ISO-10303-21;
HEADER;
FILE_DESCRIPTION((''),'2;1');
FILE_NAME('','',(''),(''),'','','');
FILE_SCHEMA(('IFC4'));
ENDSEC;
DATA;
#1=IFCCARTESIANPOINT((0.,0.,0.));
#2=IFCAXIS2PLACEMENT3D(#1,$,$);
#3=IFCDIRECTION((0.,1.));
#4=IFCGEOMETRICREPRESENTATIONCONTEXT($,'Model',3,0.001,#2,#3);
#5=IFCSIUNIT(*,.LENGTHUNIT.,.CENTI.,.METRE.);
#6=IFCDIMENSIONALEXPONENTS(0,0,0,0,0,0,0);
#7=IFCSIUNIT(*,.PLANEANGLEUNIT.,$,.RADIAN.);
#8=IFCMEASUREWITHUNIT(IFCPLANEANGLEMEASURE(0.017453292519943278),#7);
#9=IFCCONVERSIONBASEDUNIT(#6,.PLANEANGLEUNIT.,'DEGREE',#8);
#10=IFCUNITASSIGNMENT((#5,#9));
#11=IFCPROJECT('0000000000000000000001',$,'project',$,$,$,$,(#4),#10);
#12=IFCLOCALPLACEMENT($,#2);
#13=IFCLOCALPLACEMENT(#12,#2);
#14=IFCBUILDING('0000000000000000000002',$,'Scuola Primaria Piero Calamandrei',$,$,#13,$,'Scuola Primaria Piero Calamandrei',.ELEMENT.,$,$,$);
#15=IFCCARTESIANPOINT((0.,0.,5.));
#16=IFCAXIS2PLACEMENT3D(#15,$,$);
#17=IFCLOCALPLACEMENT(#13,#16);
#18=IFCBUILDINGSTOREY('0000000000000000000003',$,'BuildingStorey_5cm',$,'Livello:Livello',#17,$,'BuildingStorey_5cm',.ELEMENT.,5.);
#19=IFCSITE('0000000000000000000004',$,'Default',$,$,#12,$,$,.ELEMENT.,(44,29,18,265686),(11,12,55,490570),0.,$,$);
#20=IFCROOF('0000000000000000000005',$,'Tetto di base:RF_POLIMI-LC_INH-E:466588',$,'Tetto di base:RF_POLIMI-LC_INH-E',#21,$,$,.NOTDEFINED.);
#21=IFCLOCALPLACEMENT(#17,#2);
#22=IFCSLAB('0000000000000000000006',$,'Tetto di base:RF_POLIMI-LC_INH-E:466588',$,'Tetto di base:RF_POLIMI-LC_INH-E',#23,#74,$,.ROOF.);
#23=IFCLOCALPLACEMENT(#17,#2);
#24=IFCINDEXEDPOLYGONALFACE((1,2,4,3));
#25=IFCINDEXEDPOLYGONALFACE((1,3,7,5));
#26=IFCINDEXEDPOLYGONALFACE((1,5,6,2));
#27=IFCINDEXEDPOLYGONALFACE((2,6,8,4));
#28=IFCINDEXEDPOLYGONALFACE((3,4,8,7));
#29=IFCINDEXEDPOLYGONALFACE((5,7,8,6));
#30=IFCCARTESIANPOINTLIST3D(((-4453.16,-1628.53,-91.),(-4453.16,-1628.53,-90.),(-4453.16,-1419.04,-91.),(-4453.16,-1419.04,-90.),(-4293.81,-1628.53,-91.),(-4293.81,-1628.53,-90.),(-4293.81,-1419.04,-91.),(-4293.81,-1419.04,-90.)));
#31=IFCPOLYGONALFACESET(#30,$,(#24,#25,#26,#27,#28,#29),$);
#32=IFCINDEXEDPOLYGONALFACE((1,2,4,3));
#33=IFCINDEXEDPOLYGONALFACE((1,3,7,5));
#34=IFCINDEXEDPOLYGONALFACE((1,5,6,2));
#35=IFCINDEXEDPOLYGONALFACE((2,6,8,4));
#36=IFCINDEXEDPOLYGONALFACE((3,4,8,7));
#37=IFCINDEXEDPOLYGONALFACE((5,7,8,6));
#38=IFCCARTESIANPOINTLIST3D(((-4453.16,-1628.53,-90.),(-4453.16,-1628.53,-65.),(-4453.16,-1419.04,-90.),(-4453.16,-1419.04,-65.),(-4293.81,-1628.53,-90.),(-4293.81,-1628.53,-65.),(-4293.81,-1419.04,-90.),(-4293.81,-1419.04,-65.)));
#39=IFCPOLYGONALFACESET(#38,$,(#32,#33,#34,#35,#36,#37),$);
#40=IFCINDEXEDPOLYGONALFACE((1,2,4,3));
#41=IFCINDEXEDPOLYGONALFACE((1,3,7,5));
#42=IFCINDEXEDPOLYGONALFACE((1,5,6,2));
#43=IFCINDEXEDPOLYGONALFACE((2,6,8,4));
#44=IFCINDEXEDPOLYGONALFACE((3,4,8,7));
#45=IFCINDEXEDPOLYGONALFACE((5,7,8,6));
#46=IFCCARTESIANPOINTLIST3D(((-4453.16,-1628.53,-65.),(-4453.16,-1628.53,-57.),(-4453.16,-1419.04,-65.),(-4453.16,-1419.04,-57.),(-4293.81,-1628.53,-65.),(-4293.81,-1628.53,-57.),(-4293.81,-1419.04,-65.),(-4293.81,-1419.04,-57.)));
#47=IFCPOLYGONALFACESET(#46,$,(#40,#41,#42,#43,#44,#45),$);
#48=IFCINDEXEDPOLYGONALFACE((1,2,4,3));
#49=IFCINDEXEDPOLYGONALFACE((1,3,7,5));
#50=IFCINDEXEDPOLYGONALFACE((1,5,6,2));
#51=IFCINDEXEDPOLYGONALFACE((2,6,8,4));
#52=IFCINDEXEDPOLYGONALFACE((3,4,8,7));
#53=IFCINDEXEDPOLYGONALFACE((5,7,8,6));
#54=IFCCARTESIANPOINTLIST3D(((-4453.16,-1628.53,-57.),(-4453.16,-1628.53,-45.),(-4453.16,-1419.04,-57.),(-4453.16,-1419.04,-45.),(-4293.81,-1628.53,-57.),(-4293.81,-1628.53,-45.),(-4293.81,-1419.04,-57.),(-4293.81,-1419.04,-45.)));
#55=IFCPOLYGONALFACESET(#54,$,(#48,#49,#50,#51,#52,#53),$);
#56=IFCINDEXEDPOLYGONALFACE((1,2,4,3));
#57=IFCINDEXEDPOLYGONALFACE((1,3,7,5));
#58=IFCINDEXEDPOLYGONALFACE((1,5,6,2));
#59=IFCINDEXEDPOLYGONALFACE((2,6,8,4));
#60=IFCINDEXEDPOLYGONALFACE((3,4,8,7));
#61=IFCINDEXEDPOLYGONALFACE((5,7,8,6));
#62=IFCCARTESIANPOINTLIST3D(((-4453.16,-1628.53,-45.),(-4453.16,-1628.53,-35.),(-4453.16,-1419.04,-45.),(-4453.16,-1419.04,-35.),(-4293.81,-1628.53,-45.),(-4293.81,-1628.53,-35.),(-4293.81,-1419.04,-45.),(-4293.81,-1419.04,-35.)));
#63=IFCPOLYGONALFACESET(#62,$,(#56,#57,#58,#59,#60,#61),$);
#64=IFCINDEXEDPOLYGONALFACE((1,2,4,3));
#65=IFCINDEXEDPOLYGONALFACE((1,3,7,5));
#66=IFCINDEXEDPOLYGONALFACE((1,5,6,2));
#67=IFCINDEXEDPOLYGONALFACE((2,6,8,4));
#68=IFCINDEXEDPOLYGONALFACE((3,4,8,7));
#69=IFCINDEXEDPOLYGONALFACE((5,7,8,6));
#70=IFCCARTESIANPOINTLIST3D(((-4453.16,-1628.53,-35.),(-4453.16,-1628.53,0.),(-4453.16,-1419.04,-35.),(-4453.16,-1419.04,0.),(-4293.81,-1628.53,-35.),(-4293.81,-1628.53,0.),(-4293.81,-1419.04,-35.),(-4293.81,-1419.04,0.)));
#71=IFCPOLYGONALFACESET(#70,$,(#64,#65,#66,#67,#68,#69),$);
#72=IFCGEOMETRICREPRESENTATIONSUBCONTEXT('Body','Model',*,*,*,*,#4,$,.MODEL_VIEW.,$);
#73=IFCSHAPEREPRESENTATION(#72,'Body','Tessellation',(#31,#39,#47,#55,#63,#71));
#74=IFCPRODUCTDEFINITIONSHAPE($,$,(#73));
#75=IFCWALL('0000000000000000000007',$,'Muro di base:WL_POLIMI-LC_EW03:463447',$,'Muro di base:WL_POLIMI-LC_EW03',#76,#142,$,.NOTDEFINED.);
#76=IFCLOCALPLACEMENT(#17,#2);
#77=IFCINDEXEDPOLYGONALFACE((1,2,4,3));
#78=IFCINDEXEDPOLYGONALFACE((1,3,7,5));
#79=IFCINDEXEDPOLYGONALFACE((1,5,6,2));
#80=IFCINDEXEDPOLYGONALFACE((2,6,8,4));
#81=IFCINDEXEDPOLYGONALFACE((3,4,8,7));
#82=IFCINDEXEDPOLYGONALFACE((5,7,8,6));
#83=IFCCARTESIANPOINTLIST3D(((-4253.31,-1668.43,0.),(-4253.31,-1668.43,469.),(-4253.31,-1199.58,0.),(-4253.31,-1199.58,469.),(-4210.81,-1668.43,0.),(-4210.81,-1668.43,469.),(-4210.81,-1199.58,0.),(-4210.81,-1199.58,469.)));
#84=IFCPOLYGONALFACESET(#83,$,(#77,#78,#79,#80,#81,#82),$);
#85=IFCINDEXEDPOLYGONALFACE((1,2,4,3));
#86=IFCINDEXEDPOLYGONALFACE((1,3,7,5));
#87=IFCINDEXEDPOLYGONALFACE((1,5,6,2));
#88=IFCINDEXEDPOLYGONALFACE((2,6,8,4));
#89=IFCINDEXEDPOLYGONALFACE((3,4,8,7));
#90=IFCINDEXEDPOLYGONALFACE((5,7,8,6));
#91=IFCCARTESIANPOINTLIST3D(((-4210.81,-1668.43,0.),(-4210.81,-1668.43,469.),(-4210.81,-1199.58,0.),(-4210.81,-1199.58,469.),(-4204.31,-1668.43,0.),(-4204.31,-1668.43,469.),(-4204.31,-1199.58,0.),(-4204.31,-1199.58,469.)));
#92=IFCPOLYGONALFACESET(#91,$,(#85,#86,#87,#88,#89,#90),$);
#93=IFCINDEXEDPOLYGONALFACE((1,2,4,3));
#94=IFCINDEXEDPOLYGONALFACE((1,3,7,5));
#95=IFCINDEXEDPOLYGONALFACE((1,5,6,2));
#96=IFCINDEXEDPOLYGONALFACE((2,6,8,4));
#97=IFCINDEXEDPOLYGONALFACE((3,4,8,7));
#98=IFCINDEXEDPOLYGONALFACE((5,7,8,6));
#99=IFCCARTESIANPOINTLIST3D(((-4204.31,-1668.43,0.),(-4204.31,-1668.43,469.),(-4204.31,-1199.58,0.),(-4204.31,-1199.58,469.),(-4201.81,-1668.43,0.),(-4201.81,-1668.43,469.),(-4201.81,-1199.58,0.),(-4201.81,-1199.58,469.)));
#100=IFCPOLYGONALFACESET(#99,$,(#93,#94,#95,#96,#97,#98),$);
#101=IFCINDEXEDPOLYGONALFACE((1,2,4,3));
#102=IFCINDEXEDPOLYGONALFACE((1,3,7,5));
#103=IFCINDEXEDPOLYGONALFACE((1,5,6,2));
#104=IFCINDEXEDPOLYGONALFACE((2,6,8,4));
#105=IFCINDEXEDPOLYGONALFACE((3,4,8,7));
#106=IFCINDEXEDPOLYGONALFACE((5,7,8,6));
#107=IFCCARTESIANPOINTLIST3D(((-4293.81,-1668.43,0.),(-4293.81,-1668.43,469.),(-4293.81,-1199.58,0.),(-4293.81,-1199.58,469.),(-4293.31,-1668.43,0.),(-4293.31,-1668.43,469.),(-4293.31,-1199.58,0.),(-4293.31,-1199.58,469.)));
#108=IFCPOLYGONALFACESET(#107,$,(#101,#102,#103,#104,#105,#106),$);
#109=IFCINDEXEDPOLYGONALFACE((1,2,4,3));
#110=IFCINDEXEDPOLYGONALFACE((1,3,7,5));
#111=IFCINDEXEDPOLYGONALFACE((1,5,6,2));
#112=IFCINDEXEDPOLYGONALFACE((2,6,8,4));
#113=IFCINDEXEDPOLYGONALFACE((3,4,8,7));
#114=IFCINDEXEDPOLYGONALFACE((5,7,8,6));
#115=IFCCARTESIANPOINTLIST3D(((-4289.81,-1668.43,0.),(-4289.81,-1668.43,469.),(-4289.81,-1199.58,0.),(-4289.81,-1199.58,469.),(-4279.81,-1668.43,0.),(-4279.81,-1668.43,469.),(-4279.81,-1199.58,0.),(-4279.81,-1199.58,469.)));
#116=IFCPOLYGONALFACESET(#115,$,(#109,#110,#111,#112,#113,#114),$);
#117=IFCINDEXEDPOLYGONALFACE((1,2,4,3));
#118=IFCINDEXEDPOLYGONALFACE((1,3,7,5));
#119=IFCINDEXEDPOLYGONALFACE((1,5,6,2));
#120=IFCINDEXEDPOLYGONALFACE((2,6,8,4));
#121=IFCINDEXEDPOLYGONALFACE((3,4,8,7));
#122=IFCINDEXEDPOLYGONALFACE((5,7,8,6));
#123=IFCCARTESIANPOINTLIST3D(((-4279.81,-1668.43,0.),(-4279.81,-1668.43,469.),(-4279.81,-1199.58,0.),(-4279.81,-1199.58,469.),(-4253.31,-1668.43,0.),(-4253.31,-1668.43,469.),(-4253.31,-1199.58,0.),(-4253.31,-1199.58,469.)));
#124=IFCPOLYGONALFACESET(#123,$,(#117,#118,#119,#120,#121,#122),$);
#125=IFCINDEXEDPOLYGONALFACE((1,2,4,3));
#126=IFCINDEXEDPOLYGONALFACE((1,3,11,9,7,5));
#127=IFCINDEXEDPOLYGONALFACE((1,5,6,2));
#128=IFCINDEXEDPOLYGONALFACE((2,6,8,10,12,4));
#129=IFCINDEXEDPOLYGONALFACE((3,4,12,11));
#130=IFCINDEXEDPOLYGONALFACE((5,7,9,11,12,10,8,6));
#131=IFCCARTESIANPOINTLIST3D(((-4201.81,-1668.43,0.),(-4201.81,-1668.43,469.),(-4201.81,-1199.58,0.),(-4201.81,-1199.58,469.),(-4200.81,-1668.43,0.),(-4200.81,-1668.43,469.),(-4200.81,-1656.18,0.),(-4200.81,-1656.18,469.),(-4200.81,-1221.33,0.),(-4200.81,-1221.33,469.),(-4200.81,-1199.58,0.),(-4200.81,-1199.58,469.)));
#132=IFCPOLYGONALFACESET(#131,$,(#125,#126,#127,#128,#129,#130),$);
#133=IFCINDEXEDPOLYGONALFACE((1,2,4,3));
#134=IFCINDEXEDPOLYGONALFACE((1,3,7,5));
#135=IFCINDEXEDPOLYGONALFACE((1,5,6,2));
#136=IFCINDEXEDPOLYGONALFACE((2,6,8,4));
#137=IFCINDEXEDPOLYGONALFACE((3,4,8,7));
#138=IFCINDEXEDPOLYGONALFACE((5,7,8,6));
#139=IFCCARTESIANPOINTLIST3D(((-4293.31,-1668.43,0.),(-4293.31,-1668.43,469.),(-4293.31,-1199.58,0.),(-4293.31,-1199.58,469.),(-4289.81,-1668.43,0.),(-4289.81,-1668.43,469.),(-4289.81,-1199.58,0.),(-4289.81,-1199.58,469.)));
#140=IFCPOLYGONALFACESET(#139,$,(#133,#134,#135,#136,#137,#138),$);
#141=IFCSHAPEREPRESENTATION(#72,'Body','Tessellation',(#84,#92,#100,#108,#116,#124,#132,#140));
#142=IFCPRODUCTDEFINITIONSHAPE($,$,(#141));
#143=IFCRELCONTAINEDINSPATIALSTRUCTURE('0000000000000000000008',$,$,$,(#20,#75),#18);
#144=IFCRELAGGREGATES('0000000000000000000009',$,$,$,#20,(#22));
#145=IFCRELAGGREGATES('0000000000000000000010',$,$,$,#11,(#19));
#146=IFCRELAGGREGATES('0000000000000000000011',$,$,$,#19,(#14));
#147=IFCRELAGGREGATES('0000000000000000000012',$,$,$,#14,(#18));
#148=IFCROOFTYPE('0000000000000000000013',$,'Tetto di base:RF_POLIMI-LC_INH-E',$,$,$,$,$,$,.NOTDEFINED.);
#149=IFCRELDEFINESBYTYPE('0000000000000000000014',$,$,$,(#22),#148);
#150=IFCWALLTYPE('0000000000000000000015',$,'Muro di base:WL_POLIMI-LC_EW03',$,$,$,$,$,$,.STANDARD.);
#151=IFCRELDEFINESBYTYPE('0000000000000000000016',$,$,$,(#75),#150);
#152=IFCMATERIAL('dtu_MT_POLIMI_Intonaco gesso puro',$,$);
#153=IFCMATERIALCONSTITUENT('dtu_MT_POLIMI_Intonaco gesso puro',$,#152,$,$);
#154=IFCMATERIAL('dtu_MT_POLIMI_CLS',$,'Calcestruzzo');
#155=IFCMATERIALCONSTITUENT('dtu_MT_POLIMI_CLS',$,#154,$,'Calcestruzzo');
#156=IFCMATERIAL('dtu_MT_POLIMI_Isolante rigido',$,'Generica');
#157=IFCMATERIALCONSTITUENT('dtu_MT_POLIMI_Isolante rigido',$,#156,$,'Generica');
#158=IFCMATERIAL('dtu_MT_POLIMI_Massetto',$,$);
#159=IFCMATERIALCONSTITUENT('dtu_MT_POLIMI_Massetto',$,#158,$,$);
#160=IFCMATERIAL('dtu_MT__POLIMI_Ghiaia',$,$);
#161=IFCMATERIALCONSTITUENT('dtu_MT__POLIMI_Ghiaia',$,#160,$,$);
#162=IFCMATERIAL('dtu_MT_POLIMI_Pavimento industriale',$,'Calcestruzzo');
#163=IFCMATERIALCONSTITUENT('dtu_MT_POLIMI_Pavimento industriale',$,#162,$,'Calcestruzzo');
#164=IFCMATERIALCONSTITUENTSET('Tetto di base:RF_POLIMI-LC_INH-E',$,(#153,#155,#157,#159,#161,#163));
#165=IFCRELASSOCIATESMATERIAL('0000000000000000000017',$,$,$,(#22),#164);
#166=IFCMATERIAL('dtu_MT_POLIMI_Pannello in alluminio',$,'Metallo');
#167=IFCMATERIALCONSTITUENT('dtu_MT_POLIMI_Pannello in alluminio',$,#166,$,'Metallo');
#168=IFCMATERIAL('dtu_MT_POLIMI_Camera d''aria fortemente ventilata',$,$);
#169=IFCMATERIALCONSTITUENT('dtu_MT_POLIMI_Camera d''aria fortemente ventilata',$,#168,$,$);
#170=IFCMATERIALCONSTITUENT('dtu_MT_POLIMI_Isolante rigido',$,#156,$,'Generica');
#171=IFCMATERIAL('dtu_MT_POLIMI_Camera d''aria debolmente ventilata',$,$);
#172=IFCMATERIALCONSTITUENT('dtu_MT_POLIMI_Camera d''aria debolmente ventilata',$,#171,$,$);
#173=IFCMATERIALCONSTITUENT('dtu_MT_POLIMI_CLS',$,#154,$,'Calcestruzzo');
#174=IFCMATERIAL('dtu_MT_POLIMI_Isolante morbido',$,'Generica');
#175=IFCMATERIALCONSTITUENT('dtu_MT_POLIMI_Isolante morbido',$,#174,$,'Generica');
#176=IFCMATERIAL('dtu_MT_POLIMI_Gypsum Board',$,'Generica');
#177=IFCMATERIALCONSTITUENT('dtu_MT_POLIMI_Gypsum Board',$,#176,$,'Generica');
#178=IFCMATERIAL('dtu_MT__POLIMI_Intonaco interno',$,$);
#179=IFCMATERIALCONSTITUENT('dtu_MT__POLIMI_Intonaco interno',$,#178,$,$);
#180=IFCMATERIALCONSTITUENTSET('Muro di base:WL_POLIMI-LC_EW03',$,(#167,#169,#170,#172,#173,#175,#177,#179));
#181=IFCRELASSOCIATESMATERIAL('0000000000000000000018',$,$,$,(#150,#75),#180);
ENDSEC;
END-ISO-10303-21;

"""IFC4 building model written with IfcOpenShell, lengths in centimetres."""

from ifc_helpers import new_model, entity, si_unit, converted_unit, direction, frame, origin, place, context, subcontext, project, spatial, indexed_curve, outline, extrude, material, constituent, constituent_set, type_object, element, aggregate, save


model = new_model("IFC4")

# Units and contexts
model_context = context("Model", 3, precision=0.001, world=origin(), true_north=direction((0.0, 1.0)))
body_context = subcontext(model_context, "Body", "Model", "MODEL_VIEW")
ifc_project = project(units=[si_unit("LENGTHUNIT", "METRE", prefix="CENTI"), converted_unit("PLANEANGLEUNIT", "DEGREE", entity("IfcPlaneAngleMeasure", 0.017453292519943278), si_unit("PLANEANGLEUNIT", "RADIAN"), dimensions=[0, 0, 0, 0, 0, 0, 0])], contexts=[model_context])

# Site, building, storey
site_placement = place(None, origin())
site = spatial("IfcSite", under=ifc_project, at=site_placement, Name="Default", CompositionType="ELEMENT", RefLatitude=(44, 29, 18, 265686), RefLongitude=(11, 12, 55, 490570), RefElevation=0.0)
building_placement = place(site_placement, origin())
building = spatial("IfcBuilding", under=site, at=building_placement, Name="Scuola Primaria Piero Calamandrei", LongName="Scuola Primaria Piero Calamandrei", CompositionType="ELEMENT")
storey_placement = place(building_placement, frame((0.0, 0.0, 5.0)))
storey = spatial("IfcBuildingStorey", under=building, at=storey_placement, Name="BuildingStorey_5cm", ObjectType="Livello:Livello", LongName="BuildingStorey_5cm", CompositionType="ELEMENT", Elevation=5.0)

# Roof, slab
ifc_material_1 = material(Name="dtu_MT_POLIMI_Intonaco gesso puro")
ifc_constituent_1 = constituent(ifc_material_1, Name="dtu_MT_POLIMI_Intonaco gesso puro")
ifc_material_2 = material(Name="dtu_MT_POLIMI_CLS", Category="Calcestruzzo")
ifc_constituent_2 = constituent(ifc_material_2, Name="dtu_MT_POLIMI_CLS", Category="Calcestruzzo")
ifc_material_3 = material(Name="dtu_MT_POLIMI_Isolante rigido", Category="Generica")
ifc_constituent_3 = constituent(ifc_material_3, Name="dtu_MT_POLIMI_Isolante rigido", Category="Generica")
ifc_material_4 = material(Name="dtu_MT_POLIMI_Massetto")
ifc_constituent_4 = constituent(ifc_material_4, Name="dtu_MT_POLIMI_Massetto")
ifc_material_5 = material(Name="dtu_MT__POLIMI_Ghiaia")
ifc_constituent_5 = constituent(ifc_material_5, Name="dtu_MT__POLIMI_Ghiaia")
ifc_material_6 = material(Name="dtu_MT_POLIMI_Pavimento industriale", Category="Calcestruzzo")
ifc_constituent_6 = constituent(ifc_material_6, Name="dtu_MT_POLIMI_Pavimento industriale", Category="Calcestruzzo")
ifc_constituent_set_1 = constituent_set(constituents=[ifc_constituent_1, ifc_constituent_2, ifc_constituent_3, ifc_constituent_4, ifc_constituent_5, ifc_constituent_6], Name="Tetto di base:RF_POLIMI-LC_INH-E")
roof_type = type_object("IfcRoofType", Name="Tetto di base:RF_POLIMI-LC_INH-E", PredefinedType="NOTDEFINED")
roof_1_placement = place(storey_placement, frame((-4453.16, -1628.53, -91.0)))
roof_1 = element("IfcRoof", 1, at=roof_1_placement, inside=storey, Name="Tetto di base:RF_POLIMI-LC_INH-E:466588", ObjectType="Tetto di base:RF_POLIMI-LC_INH-E", PredefinedType="NOTDEFINED")
slab_1_placement = place(roof_1_placement, origin())
slab_1 = element("IfcSlab", 2, at=slab_1_placement, type_object=roof_type, material=ifc_constituent_set_1, Name="Tetto di base:RF_POLIMI-LC_INH-E:466588", ObjectType="Tetto di base:RF_POLIMI-LC_INH-E", PredefinedType="ROOF", context=body_context, shape_type="SweptSolid", body=[
    extrude(outline(indexed_curve([(-79.68, 104.74), (-79.68, -104.74), (79.68, -104.74), (79.68, 104.74), (-79.68, 104.74)], self_intersect=False)), frame((79.68, 104.74, 0.0)), (0.0, 0.0, 1.0), 1.0),
    extrude(outline(indexed_curve([(-79.68, 104.74), (-79.68, -104.74), (79.68, -104.74), (79.68, 104.74), (-79.68, 104.74)], self_intersect=False)), frame((79.68, 104.74, 1.0)), (0.0, 0.0, 1.0), 25.0),
    extrude(outline(indexed_curve([(-79.68, 104.74), (-79.68, -104.74), (79.68, -104.74), (79.68, 104.74), (-79.68, 104.74)], self_intersect=False)), frame((79.68, 104.74, 26.0)), (0.0, 0.0, 1.0), 8.0),
    extrude(outline(indexed_curve([(-79.68, 104.74), (-79.68, -104.74), (79.68, -104.74), (79.68, 104.74), (-79.68, 104.74)], self_intersect=False)), frame((79.68, 104.74, 34.0)), (0.0, 0.0, 1.0), 12.0),
    extrude(outline(indexed_curve([(-79.68, 104.74), (-79.68, -104.74), (79.68, -104.74), (79.68, 104.74), (-79.68, 104.74)], self_intersect=False)), frame((79.68, 104.74, 46.0)), (0.0, 0.0, 1.0), 10.0),
    extrude(outline(indexed_curve([(-79.68, 104.74), (-79.68, -104.74), (79.68, -104.74), (79.68, 104.74), (-79.68, 104.74)], self_intersect=False)), frame((79.68, 104.74, 56.0)), (0.0, 0.0, 1.0), 35.0),
])
aggregate(roof_1, [slab_1])

# Wall
ifc_material_7 = material(Name="dtu_MT_POLIMI_Pannello in alluminio", Category="Metallo")
ifc_material_8 = material(Name="dtu_MT_POLIMI_Camera d'aria fortemente ventilata")
ifc_material_9 = material(Name="dtu_MT_POLIMI_Camera d'aria debolmente ventilata")
ifc_material_10 = material(Name="dtu_MT_POLIMI_Isolante morbido", Category="Generica")
ifc_material_11 = material(Name="dtu_MT_POLIMI_Gypsum Board", Category="Generica")
ifc_material_12 = material(Name="dtu_MT__POLIMI_Intonaco interno")
ifc_constituent_7 = constituent(ifc_material_7, Name="dtu_MT_POLIMI_Pannello in alluminio", Category="Metallo")
ifc_constituent_8 = constituent(ifc_material_8, Name="dtu_MT_POLIMI_Camera d'aria fortemente ventilata")
ifc_constituent_9 = constituent(ifc_material_3, Name="dtu_MT_POLIMI_Isolante rigido", Category="Generica")
ifc_constituent_10 = constituent(ifc_material_9, Name="dtu_MT_POLIMI_Camera d'aria debolmente ventilata")
ifc_constituent_11 = constituent(ifc_material_2, Name="dtu_MT_POLIMI_CLS", Category="Calcestruzzo")
ifc_constituent_12 = constituent(ifc_material_10, Name="dtu_MT_POLIMI_Isolante morbido", Category="Generica")
ifc_constituent_13 = constituent(ifc_material_11, Name="dtu_MT_POLIMI_Gypsum Board", Category="Generica")
ifc_constituent_14 = constituent(ifc_material_12, Name="dtu_MT__POLIMI_Intonaco interno")
ifc_constituent_set_2 = constituent_set(constituents=[ifc_constituent_7, ifc_constituent_8, ifc_constituent_9, ifc_constituent_10, ifc_constituent_11, ifc_constituent_12, ifc_constituent_13, ifc_constituent_14], Name="Muro di base:WL_POLIMI-LC_EW03")
wall_type_1 = type_object("IfcWallType", Name="Muro di base:WL_POLIMI-LC_EW03", PredefinedType="STANDARD", material=ifc_constituent_set_2)
wall_1_placement = place(storey_placement, frame((-4247.31, -1668.43, 0.0), z_axis=(0.0, 0.0, 1.0), x_axis=(0.0, 1.0, 0.0)))
element("IfcWall", 3, at=wall_1_placement, inside=storey, type_object=wall_type_1, material=ifc_constituent_set_2, Name="Muro di base:WL_POLIMI-LC_EW03:463447", ObjectType="Muro di base:WL_POLIMI-LC_EW03", PredefinedType="NOTDEFINED", context=body_context, shape_type="SweptSolid", body=[
    extrude(outline(indexed_curve([(-234.43, -21.25), (234.43, -21.25), (234.43, 21.25), (-234.43, 21.25), (-234.43, -21.25)], self_intersect=False)), frame((234.43, -15.25, 0.0)), (0.0, 0.0, 1.0), 469.0),
    extrude(outline(indexed_curve([(-234.43, -3.25), (234.43, -3.25), (234.43, 3.25), (-234.43, 3.25), (-234.43, -3.25)], self_intersect=False)), frame((234.43, -39.75, 0.0)), (0.0, 0.0, 1.0), 469.0),
    extrude(outline(indexed_curve([(-234.43, -1.25), (234.43, -1.25), (234.43, 1.25), (-234.43, 1.25), (-234.43, -1.25)], self_intersect=False)), frame((234.43, -44.25, 0.0)), (0.0, 0.0, 1.0), 469.0),
    extrude(outline(indexed_curve([(-0.25, -234.43), (0.25, -234.43), (0.25, 234.43), (-0.25, 234.43), (-0.25, -234.43)], self_intersect=False)), frame((234.43, 46.25, 0.0), z_axis=(0.0, 0.0, 1.0), x_axis=(0.0, -1.0, 0.0)), (0.0, 0.0, 1.0), 469.0),
    extrude(outline(indexed_curve([(-234.43, -5.0), (234.43, -5.0), (234.43, 5.0), (-234.43, 5.0), (-234.43, -5.0)], self_intersect=False)), frame((234.43, 37.5, 0.0)), (0.0, 0.0, 1.0), 469.0),
    extrude(outline(indexed_curve([(-234.43, -13.25), (234.43, -13.25), (234.43, 13.25), (-234.43, 13.25), (-234.43, -13.25)], self_intersect=False)), frame((234.43, 19.25, 0.0)), (0.0, 0.0, 1.0), 469.0),
    extrude(outline(indexed_curve([(-220.59, -0.33), (214.26, -0.33), (236.01, -0.33), (236.01, 0.67), (-232.84, 0.67), (-232.84, -0.33), (-220.59, -0.33)], self_intersect=False)), frame((232.84, -46.17, 0.0)), (0.0, 0.0, 1.0), 469.0),
    extrude(outline(indexed_curve([(-234.43, -1.75), (234.43, -1.75), (234.43, 1.75), (-234.43, 1.75), (-234.43, -1.75)], self_intersect=False)), frame((234.43, 44.25, 0.0)), (0.0, 0.0, 1.0), 469.0),
])

save(model, "model.ifc")
